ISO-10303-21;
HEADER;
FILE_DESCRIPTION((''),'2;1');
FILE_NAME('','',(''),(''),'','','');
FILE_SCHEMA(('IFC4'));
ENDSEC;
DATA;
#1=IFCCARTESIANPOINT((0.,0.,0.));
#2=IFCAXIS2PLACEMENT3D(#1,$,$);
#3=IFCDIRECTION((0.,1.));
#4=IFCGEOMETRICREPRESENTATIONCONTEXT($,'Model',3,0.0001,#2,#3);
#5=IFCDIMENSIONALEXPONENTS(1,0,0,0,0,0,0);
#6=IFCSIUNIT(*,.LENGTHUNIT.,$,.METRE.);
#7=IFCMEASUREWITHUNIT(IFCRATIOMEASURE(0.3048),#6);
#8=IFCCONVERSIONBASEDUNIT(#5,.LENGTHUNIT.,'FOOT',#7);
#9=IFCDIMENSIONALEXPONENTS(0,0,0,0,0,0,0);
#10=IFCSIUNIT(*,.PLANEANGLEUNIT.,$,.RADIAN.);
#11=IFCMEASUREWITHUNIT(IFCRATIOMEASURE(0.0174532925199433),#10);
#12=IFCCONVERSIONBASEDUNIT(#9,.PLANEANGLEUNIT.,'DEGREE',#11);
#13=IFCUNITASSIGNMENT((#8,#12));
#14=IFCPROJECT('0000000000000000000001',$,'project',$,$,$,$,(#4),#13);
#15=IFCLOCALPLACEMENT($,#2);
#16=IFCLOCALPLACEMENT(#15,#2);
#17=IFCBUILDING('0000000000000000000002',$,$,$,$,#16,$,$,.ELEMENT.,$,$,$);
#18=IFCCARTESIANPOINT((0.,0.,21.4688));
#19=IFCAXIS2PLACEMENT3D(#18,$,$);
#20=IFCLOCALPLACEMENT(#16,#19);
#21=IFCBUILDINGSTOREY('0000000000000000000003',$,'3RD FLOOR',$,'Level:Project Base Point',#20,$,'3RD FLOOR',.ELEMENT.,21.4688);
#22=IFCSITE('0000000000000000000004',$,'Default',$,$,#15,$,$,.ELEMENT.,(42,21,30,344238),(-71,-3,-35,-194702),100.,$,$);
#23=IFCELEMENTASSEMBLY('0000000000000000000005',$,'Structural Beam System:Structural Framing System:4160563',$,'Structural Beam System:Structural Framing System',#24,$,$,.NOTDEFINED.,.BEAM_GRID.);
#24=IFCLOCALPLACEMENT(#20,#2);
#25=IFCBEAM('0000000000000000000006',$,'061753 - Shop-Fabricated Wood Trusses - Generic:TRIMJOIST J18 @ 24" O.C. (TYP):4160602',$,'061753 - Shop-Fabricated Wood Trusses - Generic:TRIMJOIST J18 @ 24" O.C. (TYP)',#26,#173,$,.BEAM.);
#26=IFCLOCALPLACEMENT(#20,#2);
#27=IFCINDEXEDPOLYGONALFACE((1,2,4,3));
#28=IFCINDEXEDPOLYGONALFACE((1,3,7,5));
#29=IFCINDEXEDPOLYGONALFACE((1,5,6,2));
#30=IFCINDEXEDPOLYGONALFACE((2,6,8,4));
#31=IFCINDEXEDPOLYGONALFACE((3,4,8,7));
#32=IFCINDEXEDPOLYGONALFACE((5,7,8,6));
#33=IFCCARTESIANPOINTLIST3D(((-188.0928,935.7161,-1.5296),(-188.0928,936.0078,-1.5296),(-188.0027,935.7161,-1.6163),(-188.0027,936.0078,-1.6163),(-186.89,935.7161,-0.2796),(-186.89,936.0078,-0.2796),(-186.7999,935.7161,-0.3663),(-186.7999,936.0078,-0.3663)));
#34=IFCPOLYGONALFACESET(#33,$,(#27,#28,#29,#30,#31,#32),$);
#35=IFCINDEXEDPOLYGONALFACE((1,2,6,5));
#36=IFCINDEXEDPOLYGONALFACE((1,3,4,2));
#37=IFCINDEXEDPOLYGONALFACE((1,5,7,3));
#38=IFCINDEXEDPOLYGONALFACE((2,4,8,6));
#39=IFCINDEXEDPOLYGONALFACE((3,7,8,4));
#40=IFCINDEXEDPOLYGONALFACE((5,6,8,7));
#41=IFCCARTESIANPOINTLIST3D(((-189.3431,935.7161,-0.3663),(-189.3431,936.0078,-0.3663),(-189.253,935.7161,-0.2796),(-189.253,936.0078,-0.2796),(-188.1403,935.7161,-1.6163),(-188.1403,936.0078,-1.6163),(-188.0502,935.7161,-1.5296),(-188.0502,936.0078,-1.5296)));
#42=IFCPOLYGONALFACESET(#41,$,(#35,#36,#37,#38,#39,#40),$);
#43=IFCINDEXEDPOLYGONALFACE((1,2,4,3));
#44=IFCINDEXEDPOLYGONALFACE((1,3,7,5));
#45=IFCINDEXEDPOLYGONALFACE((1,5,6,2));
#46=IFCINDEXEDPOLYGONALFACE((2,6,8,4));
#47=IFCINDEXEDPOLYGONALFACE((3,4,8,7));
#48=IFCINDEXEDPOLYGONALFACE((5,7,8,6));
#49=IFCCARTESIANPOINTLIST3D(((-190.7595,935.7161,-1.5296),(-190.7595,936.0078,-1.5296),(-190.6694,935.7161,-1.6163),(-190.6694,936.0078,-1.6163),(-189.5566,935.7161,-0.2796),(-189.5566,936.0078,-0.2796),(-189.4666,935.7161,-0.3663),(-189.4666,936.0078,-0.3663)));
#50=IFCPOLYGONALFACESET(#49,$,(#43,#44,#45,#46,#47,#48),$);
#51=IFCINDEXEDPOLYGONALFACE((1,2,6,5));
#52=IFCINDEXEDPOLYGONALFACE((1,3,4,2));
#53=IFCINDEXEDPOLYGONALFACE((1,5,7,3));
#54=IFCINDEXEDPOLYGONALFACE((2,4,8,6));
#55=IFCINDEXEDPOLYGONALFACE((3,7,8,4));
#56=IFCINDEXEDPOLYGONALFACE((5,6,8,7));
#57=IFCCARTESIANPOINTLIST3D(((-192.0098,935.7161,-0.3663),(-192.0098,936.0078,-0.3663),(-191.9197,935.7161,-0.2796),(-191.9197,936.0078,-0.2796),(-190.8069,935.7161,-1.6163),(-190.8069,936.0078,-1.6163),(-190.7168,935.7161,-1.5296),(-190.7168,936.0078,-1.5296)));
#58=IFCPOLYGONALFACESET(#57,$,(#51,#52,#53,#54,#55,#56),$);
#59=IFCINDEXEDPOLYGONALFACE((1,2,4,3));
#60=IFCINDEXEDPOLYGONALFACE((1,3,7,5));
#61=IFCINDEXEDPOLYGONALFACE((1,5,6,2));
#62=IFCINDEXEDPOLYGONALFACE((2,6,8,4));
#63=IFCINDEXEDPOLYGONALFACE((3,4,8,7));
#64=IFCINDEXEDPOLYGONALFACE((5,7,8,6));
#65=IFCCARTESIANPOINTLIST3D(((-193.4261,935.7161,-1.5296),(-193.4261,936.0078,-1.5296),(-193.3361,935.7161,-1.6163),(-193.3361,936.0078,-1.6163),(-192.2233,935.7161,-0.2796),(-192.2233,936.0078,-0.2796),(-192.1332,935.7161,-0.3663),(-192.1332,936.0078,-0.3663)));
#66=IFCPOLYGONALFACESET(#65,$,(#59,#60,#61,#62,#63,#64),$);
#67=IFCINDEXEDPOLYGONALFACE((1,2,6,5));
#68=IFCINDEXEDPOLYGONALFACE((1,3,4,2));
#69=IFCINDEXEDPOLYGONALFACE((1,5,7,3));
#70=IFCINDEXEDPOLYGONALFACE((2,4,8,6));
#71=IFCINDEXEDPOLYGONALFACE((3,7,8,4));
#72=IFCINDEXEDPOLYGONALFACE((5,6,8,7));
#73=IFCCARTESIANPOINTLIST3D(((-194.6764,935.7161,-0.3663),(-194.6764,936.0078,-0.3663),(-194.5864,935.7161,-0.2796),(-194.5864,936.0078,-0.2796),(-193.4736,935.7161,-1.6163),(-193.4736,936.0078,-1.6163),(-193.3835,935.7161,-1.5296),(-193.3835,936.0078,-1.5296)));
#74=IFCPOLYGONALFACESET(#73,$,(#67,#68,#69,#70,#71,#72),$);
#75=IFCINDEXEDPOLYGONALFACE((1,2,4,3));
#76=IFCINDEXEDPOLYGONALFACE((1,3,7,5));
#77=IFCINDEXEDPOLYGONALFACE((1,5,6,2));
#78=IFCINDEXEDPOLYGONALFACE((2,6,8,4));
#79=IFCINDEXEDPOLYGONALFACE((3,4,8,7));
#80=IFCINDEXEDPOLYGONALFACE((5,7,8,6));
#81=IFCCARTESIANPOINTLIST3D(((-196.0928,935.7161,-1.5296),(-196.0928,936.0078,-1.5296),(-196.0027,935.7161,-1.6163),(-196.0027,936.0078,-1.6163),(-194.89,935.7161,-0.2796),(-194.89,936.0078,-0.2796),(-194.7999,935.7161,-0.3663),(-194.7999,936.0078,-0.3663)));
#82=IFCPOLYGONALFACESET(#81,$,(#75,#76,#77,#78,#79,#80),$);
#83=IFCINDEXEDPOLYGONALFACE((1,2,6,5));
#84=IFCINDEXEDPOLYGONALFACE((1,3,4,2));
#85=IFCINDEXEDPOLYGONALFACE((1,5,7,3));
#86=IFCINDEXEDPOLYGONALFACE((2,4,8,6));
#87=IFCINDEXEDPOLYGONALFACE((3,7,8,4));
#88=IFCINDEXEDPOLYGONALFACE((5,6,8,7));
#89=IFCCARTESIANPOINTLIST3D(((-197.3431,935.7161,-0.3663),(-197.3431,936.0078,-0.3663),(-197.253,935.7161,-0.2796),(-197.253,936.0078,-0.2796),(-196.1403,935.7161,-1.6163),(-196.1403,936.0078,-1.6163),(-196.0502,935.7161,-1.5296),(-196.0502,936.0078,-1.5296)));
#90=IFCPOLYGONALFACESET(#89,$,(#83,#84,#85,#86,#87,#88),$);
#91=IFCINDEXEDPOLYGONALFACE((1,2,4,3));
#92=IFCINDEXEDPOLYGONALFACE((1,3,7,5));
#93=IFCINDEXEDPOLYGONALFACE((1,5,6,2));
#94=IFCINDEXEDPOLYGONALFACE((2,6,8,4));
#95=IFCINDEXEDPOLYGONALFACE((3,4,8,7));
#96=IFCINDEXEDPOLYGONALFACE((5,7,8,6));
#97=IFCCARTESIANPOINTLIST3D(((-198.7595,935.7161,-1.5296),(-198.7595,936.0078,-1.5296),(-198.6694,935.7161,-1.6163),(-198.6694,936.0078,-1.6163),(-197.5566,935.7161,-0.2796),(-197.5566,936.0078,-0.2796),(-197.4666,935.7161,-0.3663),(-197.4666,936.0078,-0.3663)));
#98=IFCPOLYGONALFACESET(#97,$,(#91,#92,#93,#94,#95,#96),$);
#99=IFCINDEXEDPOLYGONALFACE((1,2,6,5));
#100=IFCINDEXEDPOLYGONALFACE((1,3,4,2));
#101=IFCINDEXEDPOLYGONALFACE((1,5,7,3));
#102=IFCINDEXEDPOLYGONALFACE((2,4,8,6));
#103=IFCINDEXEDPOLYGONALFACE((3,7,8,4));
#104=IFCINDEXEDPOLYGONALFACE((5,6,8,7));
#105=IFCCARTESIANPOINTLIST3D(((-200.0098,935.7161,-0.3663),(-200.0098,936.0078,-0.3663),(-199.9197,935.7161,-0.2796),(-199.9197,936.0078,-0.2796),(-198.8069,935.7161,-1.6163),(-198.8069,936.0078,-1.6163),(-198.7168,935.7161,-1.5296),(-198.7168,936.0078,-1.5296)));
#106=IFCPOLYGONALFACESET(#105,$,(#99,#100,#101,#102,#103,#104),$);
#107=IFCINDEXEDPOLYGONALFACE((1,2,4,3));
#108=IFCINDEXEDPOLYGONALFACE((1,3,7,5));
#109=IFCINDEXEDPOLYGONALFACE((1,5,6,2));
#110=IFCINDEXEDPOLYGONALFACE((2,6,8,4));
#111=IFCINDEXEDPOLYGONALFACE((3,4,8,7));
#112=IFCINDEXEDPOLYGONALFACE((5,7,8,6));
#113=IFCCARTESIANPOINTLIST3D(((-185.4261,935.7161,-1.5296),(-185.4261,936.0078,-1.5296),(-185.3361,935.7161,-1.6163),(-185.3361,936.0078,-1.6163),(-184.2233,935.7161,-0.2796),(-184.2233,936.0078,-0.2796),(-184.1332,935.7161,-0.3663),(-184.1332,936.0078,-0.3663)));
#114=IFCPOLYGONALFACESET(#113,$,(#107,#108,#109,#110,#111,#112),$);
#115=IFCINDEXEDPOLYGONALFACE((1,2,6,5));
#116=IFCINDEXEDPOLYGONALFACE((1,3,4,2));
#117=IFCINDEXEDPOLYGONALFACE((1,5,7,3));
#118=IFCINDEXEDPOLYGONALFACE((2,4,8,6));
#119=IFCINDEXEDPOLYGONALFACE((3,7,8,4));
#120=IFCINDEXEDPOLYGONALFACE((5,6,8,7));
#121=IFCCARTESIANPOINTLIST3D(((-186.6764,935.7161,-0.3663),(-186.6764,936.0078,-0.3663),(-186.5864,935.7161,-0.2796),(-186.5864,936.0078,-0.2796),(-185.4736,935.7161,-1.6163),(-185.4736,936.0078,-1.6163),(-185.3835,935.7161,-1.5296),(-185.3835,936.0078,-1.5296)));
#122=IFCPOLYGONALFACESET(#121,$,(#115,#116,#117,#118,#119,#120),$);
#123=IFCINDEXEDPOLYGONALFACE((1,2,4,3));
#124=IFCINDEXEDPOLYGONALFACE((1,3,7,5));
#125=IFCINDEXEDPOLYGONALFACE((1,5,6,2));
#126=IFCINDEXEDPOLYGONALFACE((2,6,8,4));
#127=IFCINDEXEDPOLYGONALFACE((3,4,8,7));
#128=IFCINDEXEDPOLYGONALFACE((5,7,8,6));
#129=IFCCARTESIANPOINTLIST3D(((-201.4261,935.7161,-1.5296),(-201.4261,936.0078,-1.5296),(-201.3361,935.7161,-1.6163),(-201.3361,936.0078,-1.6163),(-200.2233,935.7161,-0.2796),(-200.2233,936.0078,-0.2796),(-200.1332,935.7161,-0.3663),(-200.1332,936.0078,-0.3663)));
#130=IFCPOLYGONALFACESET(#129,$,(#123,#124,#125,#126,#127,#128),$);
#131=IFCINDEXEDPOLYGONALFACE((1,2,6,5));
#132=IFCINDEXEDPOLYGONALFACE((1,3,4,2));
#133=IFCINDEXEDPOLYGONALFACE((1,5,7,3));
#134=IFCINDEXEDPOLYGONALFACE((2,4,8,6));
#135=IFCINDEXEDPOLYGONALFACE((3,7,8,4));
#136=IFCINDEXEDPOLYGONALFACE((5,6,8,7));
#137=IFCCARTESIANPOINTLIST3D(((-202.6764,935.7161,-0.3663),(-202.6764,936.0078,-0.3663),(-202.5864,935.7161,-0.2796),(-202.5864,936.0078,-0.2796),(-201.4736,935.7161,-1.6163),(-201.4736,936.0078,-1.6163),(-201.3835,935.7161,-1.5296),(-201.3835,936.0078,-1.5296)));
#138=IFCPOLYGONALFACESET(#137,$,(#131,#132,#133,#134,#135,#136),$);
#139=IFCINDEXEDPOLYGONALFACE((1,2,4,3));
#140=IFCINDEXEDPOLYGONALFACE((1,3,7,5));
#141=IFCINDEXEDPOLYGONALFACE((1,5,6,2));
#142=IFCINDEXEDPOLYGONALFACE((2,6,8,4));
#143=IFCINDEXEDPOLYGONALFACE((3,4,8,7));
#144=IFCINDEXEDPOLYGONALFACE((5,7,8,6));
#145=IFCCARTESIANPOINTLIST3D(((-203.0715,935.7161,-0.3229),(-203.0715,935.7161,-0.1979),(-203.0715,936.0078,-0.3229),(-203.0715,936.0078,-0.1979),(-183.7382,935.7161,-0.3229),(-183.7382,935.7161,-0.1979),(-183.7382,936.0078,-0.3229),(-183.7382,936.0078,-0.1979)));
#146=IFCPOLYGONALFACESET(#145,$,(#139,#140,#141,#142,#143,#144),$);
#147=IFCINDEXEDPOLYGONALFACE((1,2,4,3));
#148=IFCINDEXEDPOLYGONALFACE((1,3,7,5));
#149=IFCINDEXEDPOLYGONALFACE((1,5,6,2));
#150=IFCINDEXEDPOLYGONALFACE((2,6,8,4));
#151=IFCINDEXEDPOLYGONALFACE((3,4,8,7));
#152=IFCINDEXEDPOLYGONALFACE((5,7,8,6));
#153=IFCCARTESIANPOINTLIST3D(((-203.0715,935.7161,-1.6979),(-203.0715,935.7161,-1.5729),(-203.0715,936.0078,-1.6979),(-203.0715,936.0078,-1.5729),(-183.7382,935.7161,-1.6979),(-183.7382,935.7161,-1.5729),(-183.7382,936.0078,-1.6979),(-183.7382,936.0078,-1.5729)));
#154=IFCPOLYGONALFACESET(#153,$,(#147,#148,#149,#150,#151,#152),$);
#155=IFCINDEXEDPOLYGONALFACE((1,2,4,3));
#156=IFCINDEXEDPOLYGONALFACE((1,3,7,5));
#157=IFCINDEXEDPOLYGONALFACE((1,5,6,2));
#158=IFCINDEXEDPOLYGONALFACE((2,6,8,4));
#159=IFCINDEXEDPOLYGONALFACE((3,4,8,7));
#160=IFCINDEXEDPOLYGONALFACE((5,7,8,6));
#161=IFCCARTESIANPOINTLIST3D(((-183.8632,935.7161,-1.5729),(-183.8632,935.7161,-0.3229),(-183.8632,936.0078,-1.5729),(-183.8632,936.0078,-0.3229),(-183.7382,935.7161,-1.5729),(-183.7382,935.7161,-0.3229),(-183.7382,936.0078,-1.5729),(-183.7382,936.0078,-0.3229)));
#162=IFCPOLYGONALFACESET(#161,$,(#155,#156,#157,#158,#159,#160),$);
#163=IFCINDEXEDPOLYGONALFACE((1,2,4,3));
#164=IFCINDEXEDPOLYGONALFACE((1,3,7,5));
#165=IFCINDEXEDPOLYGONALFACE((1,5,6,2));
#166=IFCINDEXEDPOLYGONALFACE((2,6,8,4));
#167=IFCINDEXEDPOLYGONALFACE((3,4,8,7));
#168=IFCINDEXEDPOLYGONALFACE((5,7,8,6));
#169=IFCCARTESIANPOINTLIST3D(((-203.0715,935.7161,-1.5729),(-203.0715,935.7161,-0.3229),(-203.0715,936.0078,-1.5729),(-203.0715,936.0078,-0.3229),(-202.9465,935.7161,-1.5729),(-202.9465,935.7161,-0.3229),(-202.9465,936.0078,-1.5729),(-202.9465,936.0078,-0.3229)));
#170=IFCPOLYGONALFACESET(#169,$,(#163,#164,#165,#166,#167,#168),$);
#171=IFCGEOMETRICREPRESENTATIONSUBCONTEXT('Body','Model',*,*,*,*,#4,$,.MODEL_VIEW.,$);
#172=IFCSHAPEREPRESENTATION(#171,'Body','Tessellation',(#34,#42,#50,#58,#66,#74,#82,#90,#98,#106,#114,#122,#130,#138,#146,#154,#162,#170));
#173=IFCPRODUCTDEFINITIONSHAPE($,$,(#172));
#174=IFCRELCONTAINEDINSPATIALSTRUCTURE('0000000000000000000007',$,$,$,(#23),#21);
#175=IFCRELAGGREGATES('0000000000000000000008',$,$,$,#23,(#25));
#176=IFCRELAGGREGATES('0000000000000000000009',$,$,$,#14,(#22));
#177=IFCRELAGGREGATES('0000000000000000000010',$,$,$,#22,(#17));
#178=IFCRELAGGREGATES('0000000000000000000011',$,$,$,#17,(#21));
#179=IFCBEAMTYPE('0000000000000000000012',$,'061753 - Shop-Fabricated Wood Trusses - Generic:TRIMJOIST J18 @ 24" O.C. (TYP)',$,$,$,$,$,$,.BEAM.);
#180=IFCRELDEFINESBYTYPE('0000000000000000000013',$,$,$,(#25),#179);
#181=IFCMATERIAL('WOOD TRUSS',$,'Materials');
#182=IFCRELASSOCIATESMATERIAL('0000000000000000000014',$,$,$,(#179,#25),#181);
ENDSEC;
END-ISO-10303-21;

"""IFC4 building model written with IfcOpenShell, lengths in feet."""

from ifc_helpers import new_model, entity, si_unit, converted_unit, direction, frame, frame_2d, origin, origin_2d_with_axis, place, context, subcontext, project, spatial, rectangle, extrude, source, transform, mapped, material, material_profile, profile_set, profile_usage, type_object, type_shapes, element, aggregate, save


model = new_model("IFC4")

# Units and contexts
model_context = context("Model", 3, precision=0.0001, world=origin(), true_north=direction((0.0, 1.0)))
body_context = subcontext(model_context, "Body", "Model", "MODEL_VIEW")
ifc_project = project(units=[converted_unit("LENGTHUNIT", "FOOT", entity("IfcRatioMeasure", 0.3048), si_unit("LENGTHUNIT", "METRE"), dimensions=[1, 0, 0, 0, 0, 0, 0]), converted_unit("PLANEANGLEUNIT", "DEGREE", entity("IfcRatioMeasure", 0.0174532925199433), si_unit("PLANEANGLEUNIT", "RADIAN"), dimensions=[0, 0, 0, 0, 0, 0, 0])], contexts=[model_context])

# Site, building, storey
site_placement = place(None, origin())
site = spatial("IfcSite", under=ifc_project, at=site_placement, Name="Default", CompositionType="ELEMENT", RefLatitude=(42, 21, 30, 344238), RefLongitude=(-71, -3, -35, -194702), RefElevation=100.0)
building_placement = place(site_placement, origin())
building = spatial("IfcBuilding", under=site, at=building_placement, CompositionType="ELEMENT")
storey_placement = place(building_placement, frame((0.0, 0.0, 21.4688)))
storey = spatial("IfcBuildingStorey", under=building, at=storey_placement, Name="3RD FLOOR", ObjectType="Level:Project Base Point", LongName="3RD FLOOR", CompositionType="ELEMENT", Elevation=21.4688)

# Element assembly, beam
ifc_material = material(Name="WOOD TRUSS", Category="Materials")
ifc_material_profile_1 = material_profile(ifc_material, rectangle(XDim=1.7347, YDim=0.125, at=frame_2d((0.0, 0.0), x_axis=(1.0, 0.0))), Name="TRIMJOIST J18 @ 24\" O.C. (TYP)")
ifc_material_profile_2 = material_profile(ifc_material, rectangle(XDim=1.7347, YDim=0.125, at=frame_2d((0.0, 0.0), x_axis=(1.0, 0.0))), Name="TRIMJOIST J18 @ 24\" O.C. (TYP)")
ifc_material_profile_3 = material_profile(ifc_material, rectangle(XDim=1.7347, YDim=0.125, at=frame_2d((0.0, 0.0), x_axis=(1.0, 0.0))), Name="TRIMJOIST J18 @ 24\" O.C. (TYP)")
ifc_material_profile_4 = material_profile(ifc_material, rectangle(XDim=1.7347, YDim=0.125, at=frame_2d((0.0, 0.0), x_axis=(1.0, 0.0))), Name="TRIMJOIST J18 @ 24\" O.C. (TYP)")
ifc_material_profile_5 = material_profile(ifc_material, rectangle(XDim=1.7347, YDim=0.125, at=frame_2d((0.0, 0.0), x_axis=(1.0, 0.0))), Name="TRIMJOIST J18 @ 24\" O.C. (TYP)")
ifc_material_profile_6 = material_profile(ifc_material, rectangle(XDim=1.7347, YDim=0.125, at=frame_2d((0.0, 0.0), x_axis=(1.0, 0.0))), Name="TRIMJOIST J18 @ 24\" O.C. (TYP)")
ifc_material_profile_7 = material_profile(ifc_material, rectangle(XDim=1.7347, YDim=0.125, at=frame_2d((0.0, 0.0), x_axis=(1.0, 0.0))), Name="TRIMJOIST J18 @ 24\" O.C. (TYP)")
ifc_material_profile_8 = material_profile(ifc_material, rectangle(XDim=1.7347, YDim=0.125, at=frame_2d((0.0, 0.0), x_axis=(1.0, 0.0))), Name="TRIMJOIST J18 @ 24\" O.C. (TYP)")
ifc_material_profile_9 = material_profile(ifc_material, rectangle(XDim=1.7347, YDim=0.125, at=frame_2d((0.0, 0.0), x_axis=(1.0, 0.0))), Name="TRIMJOIST J18 @ 24\" O.C. (TYP)")
ifc_material_profile_10 = material_profile(ifc_material, rectangle(XDim=1.7347, YDim=0.125, at=origin_2d_with_axis()), Name="TRIMJOIST J18 @ 24\" O.C. (TYP)")
ifc_material_profile_11 = material_profile(ifc_material, rectangle(XDim=0.125, YDim=0.2917, at=origin_2d_with_axis()), Name="TRIMJOIST J18 @ 24\" O.C. (TYP)")
ifc_material_profile_12 = material_profile(ifc_material, rectangle(XDim=0.125, YDim=0.2917, at=origin_2d_with_axis()), Name="TRIMJOIST J18 @ 24\" O.C. (TYP)")
ifc_material_profile_13 = material_profile(ifc_material, rectangle(XDim=1.25, YDim=0.2917, at=origin_2d_with_axis()), Name="TRIMJOIST J18 @ 24\" O.C. (TYP)")
ifc_material_profile_14 = material_profile(ifc_material, rectangle(XDim=1.25, YDim=0.2917, at=origin_2d_with_axis()), Name="TRIMJOIST J18 @ 24\" O.C. (TYP)")
ifc_profile_set = profile_set([ifc_material_profile_1, ifc_material_profile_2, ifc_material_profile_3, ifc_material_profile_4, ifc_material_profile_5, ifc_material_profile_6, ifc_material_profile_7, ifc_material_profile_8, ifc_material_profile_9, ifc_material_profile_10, ifc_material_profile_11, ifc_material_profile_12, ifc_material_profile_13, ifc_material_profile_14], Name="TRIMJOIST J18 @ 24\" O.C. (TYP)")
beam_type_1 = type_object("IfcBeamType", Name="061753 - Shop-Fabricated Wood Trusses - Generic:TRIMJOIST J18 @ 24\" O.C. (TYP)", PredefinedType="BEAM", material=ifc_profile_set)
shared_shape_1 = source(origin(), body_context, "Body", "SweptSolid", [
    extrude(rectangle(XDim=1.7347, YDim=0.125, at=frame_2d((0.0, 0.0), x_axis=(1.0, 0.0))), frame((5.9585, -0.1458, 0.0), z_axis=(0.0, 1.0, 0.0), x_axis=(0.693383, 0.0, 0.720569)), (0.0, 0.0, 1.0), 0.2917),
    extrude(rectangle(XDim=1.7347, YDim=0.125, at=origin_2d_with_axis()), frame((4.7082, -0.1458, 0.0), z_axis=(0.0, 1.0, 0.0), x_axis=(0.693383, 0.0, -0.720569)), (0.0, 0.0, 1.0), 0.2917),
    extrude(rectangle(XDim=1.7347, YDim=0.125, at=frame_2d((0.0, 0.0), x_axis=(1.0, 0.0))), frame((3.2918, -0.1458, 0.0), z_axis=(0.0, 1.0, 0.0), x_axis=(0.693383, 0.0, 0.720569)), (0.0, 0.0, 1.0), 0.2917),
    extrude(rectangle(XDim=1.7347, YDim=0.125, at=frame_2d((0.0, 0.0), x_axis=(1.0, 0.0))), frame((2.0415, -0.1458, 0.0), z_axis=(0.0, 1.0, 0.0), x_axis=(0.693383, 0.0, -0.720569)), (0.0, 0.0, 1.0), 0.2917),
    extrude(rectangle(XDim=1.7347, YDim=0.125, at=frame_2d((0.0, 0.0), x_axis=(1.0, 0.0))), frame((0.6251, -0.1458, 0.0), z_axis=(0.0, 1.0, 0.0), x_axis=(0.693383, 0.0, 0.720569)), (0.0, 0.0, 1.0), 0.2917),
    extrude(rectangle(XDim=1.7347, YDim=0.125, at=frame_2d((0.0, 0.0), x_axis=(1.0, 0.0))), frame((-0.6251, -0.1458, 0.0), z_axis=(0.0, 1.0, 0.0), x_axis=(0.693383, 0.0, -0.720569)), (0.0, 0.0, 1.0), 0.2917),
    extrude(rectangle(XDim=1.7347, YDim=0.125, at=frame_2d((0.0, 0.0), x_axis=(1.0, 0.0))), frame((-2.0415, -0.1458, 0.0), z_axis=(0.0, 1.0, 0.0), x_axis=(0.693383, 0.0, 0.720569)), (0.0, 0.0, 1.0), 0.2917),
    extrude(rectangle(XDim=1.7347, YDim=0.125, at=origin_2d_with_axis()), frame((-3.2918, -0.1458, 0.0), z_axis=(0.0, 1.0, 0.0), x_axis=(0.693383, 0.0, -0.720569)), (0.0, 0.0, 1.0), 0.2917),
    extrude(rectangle(XDim=1.7347, YDim=0.125, at=frame_2d((0.0, 0.0), x_axis=(1.0, 0.0))), frame((-4.7082, -0.1458, 0.0), z_axis=(0.0, 1.0, 0.0), x_axis=(0.693383, 0.0, 0.720569)), (0.0, 0.0, 1.0), 0.2917),
    extrude(rectangle(XDim=1.7347, YDim=0.125, at=frame_2d((0.0, 0.0), x_axis=(1.0, 0.0))), frame((-5.9585, -0.1458, 0.0), z_axis=(0.0, 1.0, 0.0), x_axis=(0.693383, 0.0, -0.720569)), (0.0, 0.0, 1.0), 0.2917),
    extrude(rectangle(XDim=1.7347, YDim=0.125, at=frame_2d((0.0, 0.0), x_axis=(1.0, 0.0))), frame((8.6251, -0.1458, 0.0), z_axis=(0.0, 1.0, 0.0), x_axis=(0.693383, 0.0, 0.720569)), (0.0, 0.0, 1.0), 0.2917),
    extrude(rectangle(XDim=1.7347, YDim=0.125, at=origin_2d_with_axis()), frame((7.3749, -0.1458, 0.0), z_axis=(0.0, 1.0, 0.0), x_axis=(0.693383, 0.0, -0.720569)), (0.0, 0.0, 1.0), 0.2917),
    extrude(rectangle(XDim=1.7347, YDim=0.125, at=frame_2d((0.0, 0.0), x_axis=(1.0, 0.0))), frame((-7.3749, -0.1458, 0.0), z_axis=(0.0, 1.0, 0.0), x_axis=(0.693383, 0.0, 0.720569)), (0.0, 0.0, 1.0), 0.2917),
    extrude(rectangle(XDim=1.7347, YDim=0.125, at=origin_2d_with_axis()), frame((-8.6251, -0.1458, 0.0), z_axis=(0.0, 1.0, 0.0), x_axis=(0.693383, 0.0, -0.720569)), (0.0, 0.0, 1.0), 0.2917),
    extrude(rectangle(XDim=0.125, YDim=0.2917, at=origin_2d_with_axis()), frame((-9.6667, 0.0, 0.6875), z_axis=(1.0, 0.0, 0.0), x_axis=(0.0, 0.0, -1.0)), (0.0, 0.0, 1.0), 19.3333),
    extrude(rectangle(XDim=0.125, YDim=0.2917, at=origin_2d_with_axis()), frame((-9.6667, 0.0, -0.6875), z_axis=(1.0, 0.0, 0.0), x_axis=(0.0, 0.0, -1.0)), (0.0, 0.0, 1.0), 19.3333),
    extrude(rectangle(XDim=1.25, YDim=0.2917, at=origin_2d_with_axis()), frame((9.5417, 0.0, 0.0), z_axis=(1.0, 0.0, 0.0), x_axis=(0.0, 0.0, -1.0)), (0.0, 0.0, 1.0), 0.125),
    extrude(rectangle(XDim=1.25, YDim=0.2917, at=origin_2d_with_axis()), frame((-9.6667, 0.0, 0.0), z_axis=(1.0, 0.0, 0.0), x_axis=(0.0, 0.0, -1.0)), (0.0, 0.0, 1.0), 0.125),
])
type_shapes(beam_type_1, [shared_shape_1])
assembly_1_placement = place(storey_placement, origin())
assembly_1 = element("IfcElementAssembly", 1, at=assembly_1_placement, inside=storey, Name="Structural Beam System:Structural Framing System:4160563", ObjectType="Structural Beam System:Structural Framing System", AssemblyPlace="NOTDEFINED", PredefinedType="BEAM_GRID")
ifc_profile_usage_1 = profile_usage(ifc_profile_set, cardinal=8)
beam_1_placement = place(assembly_1_placement, frame((-193.4048, 935.8619, -0.9479)))
beam_1 = element("IfcBeam", 2, at=beam_1_placement, type_object=beam_type_1, material=ifc_profile_usage_1, Name="061753 - Shop-Fabricated Wood Trusses - Generic:TRIMJOIST J18 @ 24\" O.C. (TYP):4160602", ObjectType="061753 - Shop-Fabricated Wood Trusses - Generic:TRIMJOIST J18 @ 24\" O.C. (TYP)", PredefinedType="BEAM", context=body_context, shape_type="MappedRepresentation", body=[
    mapped(shared_shape_1, transform((0.0, 0.0, 0.0), scale=1.0)),
])
aggregate(assembly_1, [beam_1])

save(model, "model.ifc")
